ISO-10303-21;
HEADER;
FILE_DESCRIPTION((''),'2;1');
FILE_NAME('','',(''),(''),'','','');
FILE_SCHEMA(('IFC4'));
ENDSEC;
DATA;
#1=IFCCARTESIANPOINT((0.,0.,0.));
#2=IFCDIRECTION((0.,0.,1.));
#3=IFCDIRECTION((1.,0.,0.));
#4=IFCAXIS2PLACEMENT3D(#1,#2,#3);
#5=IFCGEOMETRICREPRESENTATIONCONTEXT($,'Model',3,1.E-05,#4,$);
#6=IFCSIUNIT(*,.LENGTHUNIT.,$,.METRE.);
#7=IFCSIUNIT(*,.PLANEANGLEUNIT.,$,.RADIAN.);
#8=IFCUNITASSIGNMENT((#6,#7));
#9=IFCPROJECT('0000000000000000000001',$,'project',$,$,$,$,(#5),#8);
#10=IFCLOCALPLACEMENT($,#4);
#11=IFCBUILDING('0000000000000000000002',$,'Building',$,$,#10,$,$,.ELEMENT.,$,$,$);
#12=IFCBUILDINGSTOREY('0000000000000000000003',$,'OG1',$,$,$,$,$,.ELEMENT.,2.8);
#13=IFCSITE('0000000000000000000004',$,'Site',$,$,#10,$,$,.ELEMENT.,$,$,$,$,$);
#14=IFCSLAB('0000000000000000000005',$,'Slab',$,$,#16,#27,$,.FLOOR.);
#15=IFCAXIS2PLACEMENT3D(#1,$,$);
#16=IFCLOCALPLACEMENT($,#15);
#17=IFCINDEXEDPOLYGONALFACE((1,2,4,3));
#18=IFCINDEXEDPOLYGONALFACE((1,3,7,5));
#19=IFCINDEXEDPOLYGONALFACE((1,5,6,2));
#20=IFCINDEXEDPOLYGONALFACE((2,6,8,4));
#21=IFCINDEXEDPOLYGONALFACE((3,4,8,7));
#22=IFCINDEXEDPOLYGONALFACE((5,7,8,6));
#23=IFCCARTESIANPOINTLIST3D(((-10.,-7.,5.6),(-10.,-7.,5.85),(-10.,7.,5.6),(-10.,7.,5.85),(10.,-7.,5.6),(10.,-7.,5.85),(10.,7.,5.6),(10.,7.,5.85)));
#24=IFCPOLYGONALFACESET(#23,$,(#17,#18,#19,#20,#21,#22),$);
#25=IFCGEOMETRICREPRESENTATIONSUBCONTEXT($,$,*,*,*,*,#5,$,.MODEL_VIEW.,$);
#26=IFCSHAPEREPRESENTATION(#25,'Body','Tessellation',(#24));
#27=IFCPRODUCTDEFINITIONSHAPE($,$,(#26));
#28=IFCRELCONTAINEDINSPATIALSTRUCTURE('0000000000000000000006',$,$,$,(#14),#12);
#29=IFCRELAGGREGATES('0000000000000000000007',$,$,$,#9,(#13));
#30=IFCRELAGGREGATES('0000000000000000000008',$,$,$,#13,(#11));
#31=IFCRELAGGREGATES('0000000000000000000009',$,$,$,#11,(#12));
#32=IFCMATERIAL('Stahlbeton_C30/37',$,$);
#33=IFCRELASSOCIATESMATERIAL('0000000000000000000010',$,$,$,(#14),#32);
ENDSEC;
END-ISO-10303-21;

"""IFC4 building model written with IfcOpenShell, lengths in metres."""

from ifc_helpers import new_model, si_unit, frame, frame_2d, origin, origin_with_axes, place, context, subcontext, project, spatial, rectangle, extrude, material, element, save


model = new_model("IFC4")

# Units and contexts
model_context = context("Model", 3, precision=1e-05, world=origin_with_axes())
sub_context = subcontext(model_context, None, None, "MODEL_VIEW")
ifc_project = project(units=[si_unit("LENGTHUNIT", "METRE"), si_unit("PLANEANGLEUNIT", "RADIAN")], contexts=[model_context])

# Site, building, storey
placement_1 = place(None, origin_with_axes())
site = spatial("IfcSite", under=ifc_project, at=placement_1, Name="Site", CompositionType="ELEMENT")
building = spatial("IfcBuilding", under=site, at=placement_1, Name="Building", CompositionType="ELEMENT")
storey = spatial("IfcBuildingStorey", under=building, Name="OG1", CompositionType="ELEMENT", Elevation=2.8)

# Slab
ifc_material = material(Name="Stahlbeton_C30/37")
placement_2 = place(None, origin_with_axes())
placement_3 = place(placement_2, frame((0.0, 0.0, 2.8)))
slab_placement = place(placement_3, frame((-10.0, -7.0, 2.8)))
element("IfcSlab", 1, at=slab_placement, inside=storey, material=ifc_material, Name="Slab", PredefinedType="FLOOR", context=sub_context, shape_type="SweptSolid", body=[
    extrude(rectangle(XDim=20.0, YDim=14.0, at=frame_2d((10.0, 7.0))), origin(), (0.0, 0.0, 1.0), 0.25),
])

save(model, "model.ifc")
